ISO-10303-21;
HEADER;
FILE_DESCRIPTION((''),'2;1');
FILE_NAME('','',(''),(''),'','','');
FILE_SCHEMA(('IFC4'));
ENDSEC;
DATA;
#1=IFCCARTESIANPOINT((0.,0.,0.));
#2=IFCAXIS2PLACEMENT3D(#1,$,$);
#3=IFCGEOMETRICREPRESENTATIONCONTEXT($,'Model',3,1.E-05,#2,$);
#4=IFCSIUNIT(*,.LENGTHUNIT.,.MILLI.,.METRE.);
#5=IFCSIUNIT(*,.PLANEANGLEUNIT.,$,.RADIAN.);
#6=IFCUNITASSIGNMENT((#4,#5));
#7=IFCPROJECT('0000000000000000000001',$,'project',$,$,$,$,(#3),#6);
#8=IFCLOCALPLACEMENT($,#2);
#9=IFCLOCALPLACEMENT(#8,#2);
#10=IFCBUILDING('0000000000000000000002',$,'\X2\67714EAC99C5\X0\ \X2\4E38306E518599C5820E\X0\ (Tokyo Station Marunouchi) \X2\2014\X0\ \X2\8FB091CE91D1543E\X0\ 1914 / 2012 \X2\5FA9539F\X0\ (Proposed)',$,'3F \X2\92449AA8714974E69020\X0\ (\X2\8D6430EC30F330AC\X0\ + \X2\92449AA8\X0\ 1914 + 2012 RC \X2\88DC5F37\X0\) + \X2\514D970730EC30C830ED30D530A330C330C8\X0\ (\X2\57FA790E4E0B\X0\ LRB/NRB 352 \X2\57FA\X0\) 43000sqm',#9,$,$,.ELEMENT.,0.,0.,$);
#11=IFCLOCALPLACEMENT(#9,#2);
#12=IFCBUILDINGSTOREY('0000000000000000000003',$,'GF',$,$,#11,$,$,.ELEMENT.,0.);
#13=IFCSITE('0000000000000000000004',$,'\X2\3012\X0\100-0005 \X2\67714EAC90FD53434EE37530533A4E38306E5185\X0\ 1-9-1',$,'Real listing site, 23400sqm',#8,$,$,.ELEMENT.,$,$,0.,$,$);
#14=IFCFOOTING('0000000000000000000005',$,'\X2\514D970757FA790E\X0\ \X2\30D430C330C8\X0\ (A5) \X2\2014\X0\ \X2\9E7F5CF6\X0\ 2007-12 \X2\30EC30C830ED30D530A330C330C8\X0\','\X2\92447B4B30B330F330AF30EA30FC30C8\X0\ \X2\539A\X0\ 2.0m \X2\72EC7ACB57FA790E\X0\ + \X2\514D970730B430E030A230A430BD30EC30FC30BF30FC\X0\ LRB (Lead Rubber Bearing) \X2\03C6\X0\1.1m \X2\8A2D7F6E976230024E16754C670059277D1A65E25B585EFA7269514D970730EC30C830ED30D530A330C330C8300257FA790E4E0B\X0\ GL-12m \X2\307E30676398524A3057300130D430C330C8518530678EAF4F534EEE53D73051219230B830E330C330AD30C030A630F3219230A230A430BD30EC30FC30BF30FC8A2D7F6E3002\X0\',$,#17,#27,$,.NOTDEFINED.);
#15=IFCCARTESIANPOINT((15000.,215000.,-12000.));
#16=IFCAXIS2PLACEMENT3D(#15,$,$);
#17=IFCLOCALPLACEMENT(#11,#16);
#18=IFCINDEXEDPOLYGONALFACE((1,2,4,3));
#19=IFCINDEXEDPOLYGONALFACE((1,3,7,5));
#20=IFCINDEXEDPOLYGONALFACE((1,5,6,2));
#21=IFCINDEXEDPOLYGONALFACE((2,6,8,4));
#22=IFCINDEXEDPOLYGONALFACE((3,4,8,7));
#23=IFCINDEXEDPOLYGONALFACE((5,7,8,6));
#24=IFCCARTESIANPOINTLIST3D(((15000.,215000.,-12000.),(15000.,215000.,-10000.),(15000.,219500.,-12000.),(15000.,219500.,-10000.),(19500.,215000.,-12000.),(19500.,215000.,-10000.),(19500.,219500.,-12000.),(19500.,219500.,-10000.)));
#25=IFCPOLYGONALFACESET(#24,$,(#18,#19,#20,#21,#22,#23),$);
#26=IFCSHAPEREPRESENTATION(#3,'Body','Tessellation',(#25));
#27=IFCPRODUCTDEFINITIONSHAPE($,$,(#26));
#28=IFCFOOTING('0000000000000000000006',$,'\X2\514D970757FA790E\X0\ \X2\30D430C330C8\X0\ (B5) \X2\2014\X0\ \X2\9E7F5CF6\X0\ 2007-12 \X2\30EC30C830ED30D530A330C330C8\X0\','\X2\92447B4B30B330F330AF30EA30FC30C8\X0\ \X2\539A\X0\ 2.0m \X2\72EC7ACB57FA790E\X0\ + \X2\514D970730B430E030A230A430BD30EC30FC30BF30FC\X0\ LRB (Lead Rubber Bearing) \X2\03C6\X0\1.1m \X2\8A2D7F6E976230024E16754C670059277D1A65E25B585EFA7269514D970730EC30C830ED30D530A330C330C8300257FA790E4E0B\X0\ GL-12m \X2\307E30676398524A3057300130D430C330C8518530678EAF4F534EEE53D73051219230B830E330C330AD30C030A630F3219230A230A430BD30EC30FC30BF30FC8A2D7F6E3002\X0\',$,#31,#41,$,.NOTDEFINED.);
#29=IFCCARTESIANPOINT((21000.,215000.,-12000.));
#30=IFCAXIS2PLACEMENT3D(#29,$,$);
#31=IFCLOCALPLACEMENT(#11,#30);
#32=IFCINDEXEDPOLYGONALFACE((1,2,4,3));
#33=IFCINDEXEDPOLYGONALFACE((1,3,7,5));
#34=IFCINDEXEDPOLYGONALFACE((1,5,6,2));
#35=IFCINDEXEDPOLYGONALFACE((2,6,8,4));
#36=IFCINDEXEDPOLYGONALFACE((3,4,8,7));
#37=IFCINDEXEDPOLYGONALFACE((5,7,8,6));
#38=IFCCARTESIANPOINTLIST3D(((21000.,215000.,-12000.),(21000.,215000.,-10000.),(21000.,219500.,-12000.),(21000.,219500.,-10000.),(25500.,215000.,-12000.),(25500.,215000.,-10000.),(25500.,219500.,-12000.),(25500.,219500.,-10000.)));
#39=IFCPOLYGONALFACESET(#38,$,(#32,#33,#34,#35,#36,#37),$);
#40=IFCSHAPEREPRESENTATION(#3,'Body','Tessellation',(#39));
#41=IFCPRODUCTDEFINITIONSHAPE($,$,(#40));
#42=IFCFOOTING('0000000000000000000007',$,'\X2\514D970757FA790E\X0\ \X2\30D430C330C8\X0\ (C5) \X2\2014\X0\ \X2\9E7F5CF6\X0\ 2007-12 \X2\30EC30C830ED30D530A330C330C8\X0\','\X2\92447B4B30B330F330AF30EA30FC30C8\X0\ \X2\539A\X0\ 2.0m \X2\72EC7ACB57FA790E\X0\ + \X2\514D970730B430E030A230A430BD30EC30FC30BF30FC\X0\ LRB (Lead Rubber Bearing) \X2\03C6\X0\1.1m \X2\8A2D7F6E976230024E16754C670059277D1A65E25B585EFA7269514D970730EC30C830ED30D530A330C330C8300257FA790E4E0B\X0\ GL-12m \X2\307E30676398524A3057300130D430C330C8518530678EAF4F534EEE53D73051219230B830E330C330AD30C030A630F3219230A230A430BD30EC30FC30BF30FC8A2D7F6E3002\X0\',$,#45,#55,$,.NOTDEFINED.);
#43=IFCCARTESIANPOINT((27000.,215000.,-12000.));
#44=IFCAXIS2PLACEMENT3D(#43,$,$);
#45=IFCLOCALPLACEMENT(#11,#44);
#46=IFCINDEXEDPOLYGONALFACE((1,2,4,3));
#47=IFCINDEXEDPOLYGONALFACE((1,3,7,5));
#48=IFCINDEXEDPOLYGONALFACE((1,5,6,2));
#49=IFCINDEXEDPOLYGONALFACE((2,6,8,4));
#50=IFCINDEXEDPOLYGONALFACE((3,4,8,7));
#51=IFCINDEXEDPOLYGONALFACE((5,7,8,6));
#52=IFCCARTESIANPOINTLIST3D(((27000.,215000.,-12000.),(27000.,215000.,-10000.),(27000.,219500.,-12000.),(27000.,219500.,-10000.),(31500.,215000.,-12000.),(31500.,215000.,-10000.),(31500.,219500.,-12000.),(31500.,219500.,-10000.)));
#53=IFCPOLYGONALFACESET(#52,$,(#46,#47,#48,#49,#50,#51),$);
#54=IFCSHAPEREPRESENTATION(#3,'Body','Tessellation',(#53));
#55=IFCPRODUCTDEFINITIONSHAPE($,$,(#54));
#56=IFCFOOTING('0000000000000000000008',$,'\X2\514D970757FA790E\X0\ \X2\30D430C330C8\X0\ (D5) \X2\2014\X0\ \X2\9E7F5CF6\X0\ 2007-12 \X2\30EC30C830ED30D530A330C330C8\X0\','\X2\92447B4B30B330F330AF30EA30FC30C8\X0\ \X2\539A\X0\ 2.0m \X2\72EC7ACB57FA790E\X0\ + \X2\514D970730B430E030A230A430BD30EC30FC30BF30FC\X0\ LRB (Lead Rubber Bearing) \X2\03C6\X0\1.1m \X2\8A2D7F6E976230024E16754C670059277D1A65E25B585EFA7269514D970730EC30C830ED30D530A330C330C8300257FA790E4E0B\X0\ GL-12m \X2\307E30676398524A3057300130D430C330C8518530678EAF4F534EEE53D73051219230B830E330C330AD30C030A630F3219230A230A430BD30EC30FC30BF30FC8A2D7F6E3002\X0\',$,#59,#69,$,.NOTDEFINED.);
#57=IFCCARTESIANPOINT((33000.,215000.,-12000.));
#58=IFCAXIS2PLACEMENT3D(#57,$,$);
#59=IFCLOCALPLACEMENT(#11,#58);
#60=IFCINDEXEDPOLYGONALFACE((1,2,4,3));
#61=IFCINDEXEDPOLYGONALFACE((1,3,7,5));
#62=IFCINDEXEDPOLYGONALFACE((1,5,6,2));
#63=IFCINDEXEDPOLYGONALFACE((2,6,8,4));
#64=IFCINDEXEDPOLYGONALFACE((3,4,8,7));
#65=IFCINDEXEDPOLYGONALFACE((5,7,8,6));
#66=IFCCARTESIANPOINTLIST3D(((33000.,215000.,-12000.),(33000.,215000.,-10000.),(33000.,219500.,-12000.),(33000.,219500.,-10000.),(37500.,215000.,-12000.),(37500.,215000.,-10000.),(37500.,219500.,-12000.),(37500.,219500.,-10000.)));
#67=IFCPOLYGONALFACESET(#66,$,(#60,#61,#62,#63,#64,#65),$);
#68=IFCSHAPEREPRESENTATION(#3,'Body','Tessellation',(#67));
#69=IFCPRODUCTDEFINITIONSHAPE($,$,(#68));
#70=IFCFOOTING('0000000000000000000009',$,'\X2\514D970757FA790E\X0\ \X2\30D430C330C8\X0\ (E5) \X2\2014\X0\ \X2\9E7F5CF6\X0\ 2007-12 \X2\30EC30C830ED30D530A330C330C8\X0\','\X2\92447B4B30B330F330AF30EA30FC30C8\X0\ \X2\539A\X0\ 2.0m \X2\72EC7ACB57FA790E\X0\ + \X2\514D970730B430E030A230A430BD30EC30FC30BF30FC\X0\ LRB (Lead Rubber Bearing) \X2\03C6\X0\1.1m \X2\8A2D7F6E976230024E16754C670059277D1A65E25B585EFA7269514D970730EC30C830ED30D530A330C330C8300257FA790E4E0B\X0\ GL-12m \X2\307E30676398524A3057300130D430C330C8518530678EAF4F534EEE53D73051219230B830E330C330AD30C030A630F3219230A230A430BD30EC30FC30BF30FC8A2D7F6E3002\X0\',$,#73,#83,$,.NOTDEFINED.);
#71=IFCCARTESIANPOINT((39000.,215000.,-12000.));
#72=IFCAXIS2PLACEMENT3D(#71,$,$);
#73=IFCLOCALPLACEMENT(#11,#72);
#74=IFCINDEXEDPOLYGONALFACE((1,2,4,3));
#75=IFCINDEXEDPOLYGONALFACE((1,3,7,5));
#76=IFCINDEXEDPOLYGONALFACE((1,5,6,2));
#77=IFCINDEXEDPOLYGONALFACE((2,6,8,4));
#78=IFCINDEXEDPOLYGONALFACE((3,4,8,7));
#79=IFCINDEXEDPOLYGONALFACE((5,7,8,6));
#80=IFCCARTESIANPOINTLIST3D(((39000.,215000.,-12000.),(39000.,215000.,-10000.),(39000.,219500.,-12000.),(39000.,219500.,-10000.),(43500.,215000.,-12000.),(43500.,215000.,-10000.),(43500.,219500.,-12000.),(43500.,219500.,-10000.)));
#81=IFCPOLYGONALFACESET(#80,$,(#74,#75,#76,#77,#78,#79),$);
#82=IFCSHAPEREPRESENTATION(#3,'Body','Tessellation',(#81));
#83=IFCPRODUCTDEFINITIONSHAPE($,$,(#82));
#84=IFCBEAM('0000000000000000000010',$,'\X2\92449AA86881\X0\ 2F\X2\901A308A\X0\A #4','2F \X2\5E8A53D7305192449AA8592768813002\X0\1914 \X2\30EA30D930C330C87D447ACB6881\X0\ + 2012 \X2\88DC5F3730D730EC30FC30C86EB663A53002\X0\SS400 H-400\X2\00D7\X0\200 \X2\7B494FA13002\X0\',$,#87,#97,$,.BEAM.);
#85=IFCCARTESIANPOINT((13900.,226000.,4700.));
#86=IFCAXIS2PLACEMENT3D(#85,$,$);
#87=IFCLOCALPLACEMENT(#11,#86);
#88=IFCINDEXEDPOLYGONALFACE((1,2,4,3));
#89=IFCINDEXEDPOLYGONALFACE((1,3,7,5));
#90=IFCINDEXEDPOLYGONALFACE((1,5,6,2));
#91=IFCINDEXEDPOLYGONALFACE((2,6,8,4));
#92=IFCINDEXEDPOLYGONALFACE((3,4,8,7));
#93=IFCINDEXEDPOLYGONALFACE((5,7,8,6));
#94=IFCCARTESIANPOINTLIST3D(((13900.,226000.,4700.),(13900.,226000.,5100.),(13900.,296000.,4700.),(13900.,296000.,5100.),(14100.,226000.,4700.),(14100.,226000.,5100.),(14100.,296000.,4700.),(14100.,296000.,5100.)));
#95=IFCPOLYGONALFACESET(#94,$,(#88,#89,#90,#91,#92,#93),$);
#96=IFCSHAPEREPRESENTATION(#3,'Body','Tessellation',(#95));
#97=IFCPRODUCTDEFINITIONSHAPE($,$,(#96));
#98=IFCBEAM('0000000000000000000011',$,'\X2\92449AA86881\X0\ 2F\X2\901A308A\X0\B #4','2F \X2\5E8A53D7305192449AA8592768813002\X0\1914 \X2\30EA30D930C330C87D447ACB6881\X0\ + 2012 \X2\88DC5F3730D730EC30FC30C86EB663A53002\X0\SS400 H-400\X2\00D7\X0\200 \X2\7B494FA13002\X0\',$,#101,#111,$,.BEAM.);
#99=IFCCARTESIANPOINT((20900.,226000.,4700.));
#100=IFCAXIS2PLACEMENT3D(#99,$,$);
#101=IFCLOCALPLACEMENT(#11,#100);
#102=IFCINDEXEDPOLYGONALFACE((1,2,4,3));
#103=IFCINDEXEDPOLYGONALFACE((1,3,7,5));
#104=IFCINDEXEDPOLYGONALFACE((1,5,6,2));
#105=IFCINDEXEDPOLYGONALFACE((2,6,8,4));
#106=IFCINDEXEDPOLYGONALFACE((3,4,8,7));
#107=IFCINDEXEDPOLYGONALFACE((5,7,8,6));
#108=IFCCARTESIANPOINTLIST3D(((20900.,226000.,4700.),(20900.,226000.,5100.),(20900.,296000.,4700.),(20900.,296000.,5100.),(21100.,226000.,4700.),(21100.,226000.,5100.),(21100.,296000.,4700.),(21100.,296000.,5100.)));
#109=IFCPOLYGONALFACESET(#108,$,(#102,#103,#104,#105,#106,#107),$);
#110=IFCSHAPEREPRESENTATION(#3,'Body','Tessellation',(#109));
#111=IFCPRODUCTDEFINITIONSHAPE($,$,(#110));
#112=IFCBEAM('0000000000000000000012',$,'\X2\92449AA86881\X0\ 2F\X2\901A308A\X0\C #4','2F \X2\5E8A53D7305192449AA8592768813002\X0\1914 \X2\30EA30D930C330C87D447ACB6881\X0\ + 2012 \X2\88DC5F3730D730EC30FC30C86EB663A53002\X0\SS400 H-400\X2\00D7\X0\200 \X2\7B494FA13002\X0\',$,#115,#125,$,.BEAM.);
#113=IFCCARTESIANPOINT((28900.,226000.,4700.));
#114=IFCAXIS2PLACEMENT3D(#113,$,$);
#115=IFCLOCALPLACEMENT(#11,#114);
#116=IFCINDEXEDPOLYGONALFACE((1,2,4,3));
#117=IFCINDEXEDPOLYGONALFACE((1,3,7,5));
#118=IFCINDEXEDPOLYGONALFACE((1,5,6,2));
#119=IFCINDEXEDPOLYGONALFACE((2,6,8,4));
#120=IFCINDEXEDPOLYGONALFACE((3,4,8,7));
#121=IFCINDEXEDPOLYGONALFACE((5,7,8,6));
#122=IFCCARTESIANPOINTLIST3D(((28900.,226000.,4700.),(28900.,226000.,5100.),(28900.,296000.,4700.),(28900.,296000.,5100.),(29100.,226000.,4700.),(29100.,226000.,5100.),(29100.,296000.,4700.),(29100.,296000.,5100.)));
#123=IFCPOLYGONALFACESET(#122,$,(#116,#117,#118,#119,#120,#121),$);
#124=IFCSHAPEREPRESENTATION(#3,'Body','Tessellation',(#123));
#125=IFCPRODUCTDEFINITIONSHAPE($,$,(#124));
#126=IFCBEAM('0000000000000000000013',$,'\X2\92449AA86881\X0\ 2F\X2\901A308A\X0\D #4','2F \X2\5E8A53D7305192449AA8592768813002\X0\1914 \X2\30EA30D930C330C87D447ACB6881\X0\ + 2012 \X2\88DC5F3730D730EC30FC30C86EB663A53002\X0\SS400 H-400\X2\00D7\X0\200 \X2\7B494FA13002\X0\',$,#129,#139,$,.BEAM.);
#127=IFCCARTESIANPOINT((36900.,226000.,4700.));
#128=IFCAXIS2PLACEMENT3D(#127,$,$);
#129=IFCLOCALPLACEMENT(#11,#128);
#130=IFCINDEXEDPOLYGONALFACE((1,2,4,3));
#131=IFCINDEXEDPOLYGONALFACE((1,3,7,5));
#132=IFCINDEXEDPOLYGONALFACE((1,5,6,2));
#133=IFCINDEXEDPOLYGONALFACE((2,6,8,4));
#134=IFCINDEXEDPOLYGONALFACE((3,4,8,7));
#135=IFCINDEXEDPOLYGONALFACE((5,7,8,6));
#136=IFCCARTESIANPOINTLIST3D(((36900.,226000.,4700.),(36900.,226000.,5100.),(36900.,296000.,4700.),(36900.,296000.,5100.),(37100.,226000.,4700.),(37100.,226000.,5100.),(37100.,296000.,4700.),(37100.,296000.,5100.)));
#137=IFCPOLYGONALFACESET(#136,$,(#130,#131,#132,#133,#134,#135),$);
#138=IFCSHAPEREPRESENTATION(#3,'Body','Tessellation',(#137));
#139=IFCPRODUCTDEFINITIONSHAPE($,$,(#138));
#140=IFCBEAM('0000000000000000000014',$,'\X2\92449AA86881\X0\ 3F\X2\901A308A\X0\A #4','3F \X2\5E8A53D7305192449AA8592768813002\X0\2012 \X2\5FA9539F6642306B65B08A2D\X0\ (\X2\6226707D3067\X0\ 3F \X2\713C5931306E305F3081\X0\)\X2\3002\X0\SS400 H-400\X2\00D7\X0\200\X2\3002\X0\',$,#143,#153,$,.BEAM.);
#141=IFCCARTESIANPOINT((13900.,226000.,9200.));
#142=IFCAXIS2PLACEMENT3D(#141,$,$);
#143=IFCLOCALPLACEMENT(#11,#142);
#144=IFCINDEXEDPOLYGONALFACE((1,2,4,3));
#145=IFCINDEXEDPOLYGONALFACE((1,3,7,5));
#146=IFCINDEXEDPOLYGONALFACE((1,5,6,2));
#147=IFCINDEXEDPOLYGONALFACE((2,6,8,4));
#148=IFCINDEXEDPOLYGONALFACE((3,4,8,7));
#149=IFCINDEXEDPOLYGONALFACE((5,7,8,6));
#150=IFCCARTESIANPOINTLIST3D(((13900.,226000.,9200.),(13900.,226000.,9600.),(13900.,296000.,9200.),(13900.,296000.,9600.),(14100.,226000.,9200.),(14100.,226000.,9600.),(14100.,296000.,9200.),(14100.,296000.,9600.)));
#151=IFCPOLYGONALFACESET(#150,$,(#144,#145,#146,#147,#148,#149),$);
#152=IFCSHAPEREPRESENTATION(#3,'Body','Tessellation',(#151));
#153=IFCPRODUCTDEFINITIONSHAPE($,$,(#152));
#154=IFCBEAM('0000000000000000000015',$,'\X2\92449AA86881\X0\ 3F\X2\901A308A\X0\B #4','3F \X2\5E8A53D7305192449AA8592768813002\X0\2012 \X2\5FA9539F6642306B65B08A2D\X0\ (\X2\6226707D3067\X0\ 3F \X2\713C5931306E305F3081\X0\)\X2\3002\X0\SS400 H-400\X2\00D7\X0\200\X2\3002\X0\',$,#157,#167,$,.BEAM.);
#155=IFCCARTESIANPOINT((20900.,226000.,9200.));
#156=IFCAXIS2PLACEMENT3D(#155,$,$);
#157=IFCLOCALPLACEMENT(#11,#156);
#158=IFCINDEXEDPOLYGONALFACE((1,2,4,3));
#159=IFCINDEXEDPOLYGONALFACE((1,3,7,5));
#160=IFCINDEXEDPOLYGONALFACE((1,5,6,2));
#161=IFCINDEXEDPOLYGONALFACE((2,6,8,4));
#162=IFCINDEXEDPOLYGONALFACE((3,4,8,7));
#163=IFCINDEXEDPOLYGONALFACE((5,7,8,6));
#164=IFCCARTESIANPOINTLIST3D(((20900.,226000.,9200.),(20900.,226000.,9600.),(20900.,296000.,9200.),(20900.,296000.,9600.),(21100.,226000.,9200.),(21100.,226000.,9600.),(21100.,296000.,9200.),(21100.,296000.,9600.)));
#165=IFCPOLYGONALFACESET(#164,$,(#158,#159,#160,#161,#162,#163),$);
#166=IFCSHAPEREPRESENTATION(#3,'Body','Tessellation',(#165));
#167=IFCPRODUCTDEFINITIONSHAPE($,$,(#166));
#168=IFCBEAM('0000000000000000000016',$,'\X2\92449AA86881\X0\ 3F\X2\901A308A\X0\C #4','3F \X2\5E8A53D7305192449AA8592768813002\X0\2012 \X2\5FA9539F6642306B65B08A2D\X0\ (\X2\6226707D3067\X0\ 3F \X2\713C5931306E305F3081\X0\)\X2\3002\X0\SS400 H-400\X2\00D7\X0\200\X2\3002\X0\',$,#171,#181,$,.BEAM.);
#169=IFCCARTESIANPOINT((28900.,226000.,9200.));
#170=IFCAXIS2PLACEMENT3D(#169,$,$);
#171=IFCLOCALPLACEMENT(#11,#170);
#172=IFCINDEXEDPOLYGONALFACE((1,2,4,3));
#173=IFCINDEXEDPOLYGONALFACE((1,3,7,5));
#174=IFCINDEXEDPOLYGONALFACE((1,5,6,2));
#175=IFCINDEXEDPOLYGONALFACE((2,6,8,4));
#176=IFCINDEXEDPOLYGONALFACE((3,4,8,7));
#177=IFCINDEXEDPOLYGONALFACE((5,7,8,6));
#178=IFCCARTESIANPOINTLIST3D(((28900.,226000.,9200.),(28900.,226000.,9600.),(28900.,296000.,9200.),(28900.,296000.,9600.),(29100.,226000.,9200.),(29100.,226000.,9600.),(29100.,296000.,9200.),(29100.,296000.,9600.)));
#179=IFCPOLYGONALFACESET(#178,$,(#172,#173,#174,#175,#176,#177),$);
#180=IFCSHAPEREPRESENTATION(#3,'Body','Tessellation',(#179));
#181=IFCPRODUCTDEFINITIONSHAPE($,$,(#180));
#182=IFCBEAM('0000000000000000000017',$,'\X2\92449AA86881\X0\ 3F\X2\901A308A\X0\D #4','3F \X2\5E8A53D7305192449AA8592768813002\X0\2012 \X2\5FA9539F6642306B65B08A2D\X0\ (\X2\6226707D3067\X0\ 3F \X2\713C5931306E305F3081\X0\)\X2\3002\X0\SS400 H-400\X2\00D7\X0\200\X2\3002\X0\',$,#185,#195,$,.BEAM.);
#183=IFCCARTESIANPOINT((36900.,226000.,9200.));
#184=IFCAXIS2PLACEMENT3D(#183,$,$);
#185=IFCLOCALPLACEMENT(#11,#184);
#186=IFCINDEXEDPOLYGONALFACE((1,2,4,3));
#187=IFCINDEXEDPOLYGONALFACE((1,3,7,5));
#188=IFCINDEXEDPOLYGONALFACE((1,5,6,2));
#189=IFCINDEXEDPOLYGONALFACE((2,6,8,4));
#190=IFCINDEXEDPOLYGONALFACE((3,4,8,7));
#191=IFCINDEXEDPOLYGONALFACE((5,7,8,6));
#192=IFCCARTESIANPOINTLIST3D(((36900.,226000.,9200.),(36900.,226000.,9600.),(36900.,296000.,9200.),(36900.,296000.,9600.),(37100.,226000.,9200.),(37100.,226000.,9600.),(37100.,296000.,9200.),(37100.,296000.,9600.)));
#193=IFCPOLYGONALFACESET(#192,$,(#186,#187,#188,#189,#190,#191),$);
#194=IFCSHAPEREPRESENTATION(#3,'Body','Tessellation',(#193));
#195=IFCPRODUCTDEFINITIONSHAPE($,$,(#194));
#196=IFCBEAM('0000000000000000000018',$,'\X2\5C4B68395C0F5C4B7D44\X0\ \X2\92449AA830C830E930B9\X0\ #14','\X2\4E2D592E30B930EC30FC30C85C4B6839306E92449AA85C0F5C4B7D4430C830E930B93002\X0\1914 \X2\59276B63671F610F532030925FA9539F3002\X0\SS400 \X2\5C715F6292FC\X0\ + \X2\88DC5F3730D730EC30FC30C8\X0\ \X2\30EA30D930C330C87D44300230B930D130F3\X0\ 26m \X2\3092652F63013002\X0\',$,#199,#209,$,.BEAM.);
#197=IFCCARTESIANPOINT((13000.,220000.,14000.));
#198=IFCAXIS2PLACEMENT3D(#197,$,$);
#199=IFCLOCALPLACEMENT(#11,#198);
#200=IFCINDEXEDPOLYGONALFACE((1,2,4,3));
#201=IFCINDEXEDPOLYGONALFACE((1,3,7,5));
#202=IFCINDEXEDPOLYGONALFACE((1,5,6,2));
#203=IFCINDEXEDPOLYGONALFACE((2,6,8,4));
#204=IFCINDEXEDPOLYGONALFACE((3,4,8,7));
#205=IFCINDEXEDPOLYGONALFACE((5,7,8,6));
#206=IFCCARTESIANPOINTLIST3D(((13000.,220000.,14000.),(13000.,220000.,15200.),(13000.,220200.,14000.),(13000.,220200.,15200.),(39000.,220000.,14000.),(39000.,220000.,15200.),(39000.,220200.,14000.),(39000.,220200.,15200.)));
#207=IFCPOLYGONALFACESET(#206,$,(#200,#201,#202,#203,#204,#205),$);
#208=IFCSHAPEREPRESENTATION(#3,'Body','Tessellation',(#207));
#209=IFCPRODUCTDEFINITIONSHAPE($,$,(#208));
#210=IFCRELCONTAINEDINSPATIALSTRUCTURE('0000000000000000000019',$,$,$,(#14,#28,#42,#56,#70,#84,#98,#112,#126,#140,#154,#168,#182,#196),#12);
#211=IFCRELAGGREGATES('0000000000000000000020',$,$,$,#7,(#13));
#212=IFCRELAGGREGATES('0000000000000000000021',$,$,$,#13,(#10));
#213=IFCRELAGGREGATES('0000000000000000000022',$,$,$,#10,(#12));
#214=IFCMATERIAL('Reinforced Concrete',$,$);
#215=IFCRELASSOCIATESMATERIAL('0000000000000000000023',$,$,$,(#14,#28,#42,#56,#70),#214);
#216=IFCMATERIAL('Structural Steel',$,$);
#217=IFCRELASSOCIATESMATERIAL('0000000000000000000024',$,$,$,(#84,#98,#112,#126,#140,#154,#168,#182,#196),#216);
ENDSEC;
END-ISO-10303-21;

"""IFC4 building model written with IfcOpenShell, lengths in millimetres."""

from ifc_helpers import new_model, si_unit, frame, frame_2d, origin, place, context, project, spatial, rectangle, extrude, material, element, save


model = new_model("IFC4")

# Units and contexts
model_context = context("Model", 3, precision=1e-05, world=origin())
ifc_project = project(units=[si_unit("LENGTHUNIT", "METRE", prefix="MILLI"), si_unit("PLANEANGLEUNIT", "RADIAN")], contexts=[model_context])

# Site, building, storey
site_placement = place(None, origin())
site = spatial("IfcSite", under=ifc_project, at=site_placement, Name="〒100-0005 東京都千代田区丸の内 1-9-1", ObjectType="Real listing site, 23400sqm", CompositionType="ELEMENT", RefElevation=0.0)
building_placement = place(site_placement, origin())
building = spatial("IfcBuilding", under=site, at=building_placement, Name="東京駅 丸の内駅舎 (Tokyo Station Marunouchi) — 辰野金吾 1914 / 2012 復原 (Proposed)", ObjectType="3F 鉄骨煉瓦造 (赤レンガ + 鉄骨 1914 + 2012 RC 補強) + 免震レトロフィット (基礎下 LRB/NRB 352 基) 43000sqm", CompositionType="ELEMENT", ElevationOfRefHeight=0.0, ElevationOfTerrain=0.0)
storey_placement = place(building_placement, origin())
storey = spatial("IfcBuildingStorey", under=building, at=storey_placement, Name="GF", CompositionType="ELEMENT", Elevation=0.0)

# Footings
ifc_material_1 = material(Name="Reinforced Concrete")
footing_1_placement = place(storey_placement, frame((15000.0, 215000.0, -12000.0)))
element("IfcFooting", 1, at=footing_1_placement, inside=storey, material=ifc_material_1, Name="免震基礎 ピット (A5) — 鹿島 2007-12 レトロフィット", Description="鉄筋コンクリート 厚 2.0m 独立基礎 + 免震ゴムアイソレーター LRB (Lead Rubber Bearing) φ1.1m 設置面。世界最大級既存建物免震レトロフィット。基礎下 GL-12m まで掘削し、ピット内で躯体仮受け→ジャッキダウン→アイソレーター設置。", PredefinedType="NOTDEFINED", context=model_context, shape_type="SweptSolid", body=[
    extrude(rectangle(XDim=4500.0, YDim=4500.0, at=frame_2d((2250.0, 2250.0))), frame((15000.0, 215000.0, -12000.0)), (0.0, 0.0, 1.0), 2000.0),
])
footing_2_placement = place(storey_placement, frame((21000.0, 215000.0, -12000.0)))
element("IfcFooting", 2, at=footing_2_placement, inside=storey, material=ifc_material_1, Name="免震基礎 ピット (B5) — 鹿島 2007-12 レトロフィット", Description="鉄筋コンクリート 厚 2.0m 独立基礎 + 免震ゴムアイソレーター LRB (Lead Rubber Bearing) φ1.1m 設置面。世界最大級既存建物免震レトロフィット。基礎下 GL-12m まで掘削し、ピット内で躯体仮受け→ジャッキダウン→アイソレーター設置。", PredefinedType="NOTDEFINED", context=model_context, shape_type="SweptSolid", body=[
    extrude(rectangle(XDim=4500.0, YDim=4500.0, at=frame_2d((2250.0, 2250.0))), frame((21000.0, 215000.0, -12000.0)), (0.0, 0.0, 1.0), 2000.0),
])
footing_3_placement = place(storey_placement, frame((27000.0, 215000.0, -12000.0)))
element("IfcFooting", 3, at=footing_3_placement, inside=storey, material=ifc_material_1, Name="免震基礎 ピット (C5) — 鹿島 2007-12 レトロフィット", Description="鉄筋コンクリート 厚 2.0m 独立基礎 + 免震ゴムアイソレーター LRB (Lead Rubber Bearing) φ1.1m 設置面。世界最大級既存建物免震レトロフィット。基礎下 GL-12m まで掘削し、ピット内で躯体仮受け→ジャッキダウン→アイソレーター設置。", PredefinedType="NOTDEFINED", context=model_context, shape_type="SweptSolid", body=[
    extrude(rectangle(XDim=4500.0, YDim=4500.0, at=frame_2d((2250.0, 2250.0))), frame((27000.0, 215000.0, -12000.0)), (0.0, 0.0, 1.0), 2000.0),
])
footing_4_placement = place(storey_placement, frame((33000.0, 215000.0, -12000.0)))
element("IfcFooting", 4, at=footing_4_placement, inside=storey, material=ifc_material_1, Name="免震基礎 ピット (D5) — 鹿島 2007-12 レトロフィット", Description="鉄筋コンクリート 厚 2.0m 独立基礎 + 免震ゴムアイソレーター LRB (Lead Rubber Bearing) φ1.1m 設置面。世界最大級既存建物免震レトロフィット。基礎下 GL-12m まで掘削し、ピット内で躯体仮受け→ジャッキダウン→アイソレーター設置。", PredefinedType="NOTDEFINED", context=model_context, shape_type="SweptSolid", body=[
    extrude(rectangle(XDim=4500.0, YDim=4500.0, at=frame_2d((2250.0, 2250.0))), frame((33000.0, 215000.0, -12000.0)), (0.0, 0.0, 1.0), 2000.0),
])
footing_5_placement = place(storey_placement, frame((39000.0, 215000.0, -12000.0)))
element("IfcFooting", 5, at=footing_5_placement, inside=storey, material=ifc_material_1, Name="免震基礎 ピット (E5) — 鹿島 2007-12 レトロフィット", Description="鉄筋コンクリート 厚 2.0m 独立基礎 + 免震ゴムアイソレーター LRB (Lead Rubber Bearing) φ1.1m 設置面。世界最大級既存建物免震レトロフィット。基礎下 GL-12m まで掘削し、ピット内で躯体仮受け→ジャッキダウン→アイソレーター設置。", PredefinedType="NOTDEFINED", context=model_context, shape_type="SweptSolid", body=[
    extrude(rectangle(XDim=4500.0, YDim=4500.0, at=frame_2d((2250.0, 2250.0))), frame((39000.0, 215000.0, -12000.0)), (0.0, 0.0, 1.0), 2000.0),
])

# Beams
ifc_material_2 = material(Name="Structural Steel")
beam_1_placement = place(storey_placement, frame((13900.0, 226000.0, 4700.0)))
element("IfcBeam", 6, at=beam_1_placement, inside=storey, material=ifc_material_2, Name="鉄骨梁 2F通りA #4", Description="2F 床受け鉄骨大梁。1914 リベット組立梁 + 2012 補強プレート溶接。SS400 H-400×200 等価。", PredefinedType="BEAM", context=model_context, shape_type="SweptSolid", body=[
    extrude(rectangle(XDim=200.0, YDim=70000.0, at=frame_2d((100.0, 35000.0))), frame((13900.0, 226000.0, 4700.0)), (0.0, 0.0, 1.0), 400.0),
])
beam_2_placement = place(storey_placement, frame((20900.0, 226000.0, 4700.0)))
element("IfcBeam", 7, at=beam_2_placement, inside=storey, material=ifc_material_2, Name="鉄骨梁 2F通りB #4", Description="2F 床受け鉄骨大梁。1914 リベット組立梁 + 2012 補強プレート溶接。SS400 H-400×200 等価。", PredefinedType="BEAM", context=model_context, shape_type="SweptSolid", body=[
    extrude(rectangle(XDim=200.0, YDim=70000.0, at=frame_2d((100.0, 35000.0))), frame((20900.0, 226000.0, 4700.0)), (0.0, 0.0, 1.0), 400.0),
])
beam_3_placement = place(storey_placement, frame((28900.0, 226000.0, 4700.0)))
element("IfcBeam", 8, at=beam_3_placement, inside=storey, material=ifc_material_2, Name="鉄骨梁 2F通りC #4", Description="2F 床受け鉄骨大梁。1914 リベット組立梁 + 2012 補強プレート溶接。SS400 H-400×200 等価。", PredefinedType="BEAM", context=model_context, shape_type="SweptSolid", body=[
    extrude(rectangle(XDim=200.0, YDim=70000.0, at=frame_2d((100.0, 35000.0))), frame((28900.0, 226000.0, 4700.0)), (0.0, 0.0, 1.0), 400.0),
])
beam_4_placement = place(storey_placement, frame((36900.0, 226000.0, 4700.0)))
element("IfcBeam", 9, at=beam_4_placement, inside=storey, material=ifc_material_2, Name="鉄骨梁 2F通りD #4", Description="2F 床受け鉄骨大梁。1914 リベット組立梁 + 2012 補強プレート溶接。SS400 H-400×200 等価。", PredefinedType="BEAM", context=model_context, shape_type="SweptSolid", body=[
    extrude(rectangle(XDim=200.0, YDim=70000.0, at=frame_2d((100.0, 35000.0))), frame((36900.0, 226000.0, 4700.0)), (0.0, 0.0, 1.0), 400.0),
])
beam_5_placement = place(storey_placement, frame((13900.0, 226000.0, 9200.0)))
element("IfcBeam", 10, at=beam_5_placement, inside=storey, material=ifc_material_2, Name="鉄骨梁 3F通りA #4", Description="3F 床受け鉄骨大梁。2012 復原時に新設 (戦災で 3F 焼失のため)。SS400 H-400×200。", PredefinedType="BEAM", context=model_context, shape_type="SweptSolid", body=[
    extrude(rectangle(XDim=200.0, YDim=70000.0, at=frame_2d((100.0, 35000.0))), frame((13900.0, 226000.0, 9200.0)), (0.0, 0.0, 1.0), 400.0),
])
beam_6_placement = place(storey_placement, frame((20900.0, 226000.0, 9200.0)))
element("IfcBeam", 11, at=beam_6_placement, inside=storey, material=ifc_material_2, Name="鉄骨梁 3F通りB #4", Description="3F 床受け鉄骨大梁。2012 復原時に新設 (戦災で 3F 焼失のため)。SS400 H-400×200。", PredefinedType="BEAM", context=model_context, shape_type="SweptSolid", body=[
    extrude(rectangle(XDim=200.0, YDim=70000.0, at=frame_2d((100.0, 35000.0))), frame((20900.0, 226000.0, 9200.0)), (0.0, 0.0, 1.0), 400.0),
])
beam_7_placement = place(storey_placement, frame((28900.0, 226000.0, 9200.0)))
element("IfcBeam", 12, at=beam_7_placement, inside=storey, material=ifc_material_2, Name="鉄骨梁 3F通りC #4", Description="3F 床受け鉄骨大梁。2012 復原時に新設 (戦災で 3F 焼失のため)。SS400 H-400×200。", PredefinedType="BEAM", context=model_context, shape_type="SweptSolid", body=[
    extrude(rectangle(XDim=200.0, YDim=70000.0, at=frame_2d((100.0, 35000.0))), frame((28900.0, 226000.0, 9200.0)), (0.0, 0.0, 1.0), 400.0),
])
beam_8_placement = place(storey_placement, frame((36900.0, 226000.0, 9200.0)))
element("IfcBeam", 13, at=beam_8_placement, inside=storey, material=ifc_material_2, Name="鉄骨梁 3F通りD #4", Description="3F 床受け鉄骨大梁。2012 復原時に新設 (戦災で 3F 焼失のため)。SS400 H-400×200。", PredefinedType="BEAM", context=model_context, shape_type="SweptSolid", body=[
    extrude(rectangle(XDim=200.0, YDim=70000.0, at=frame_2d((100.0, 35000.0))), frame((36900.0, 226000.0, 9200.0)), (0.0, 0.0, 1.0), 400.0),
])
beam_9_placement = place(storey_placement, frame((13000.0, 220000.0, 14000.0)))
element("IfcBeam", 14, at=beam_9_placement, inside=storey, material=ifc_material_2, Name="屋根小屋組 鉄骨トラス #14", Description="中央スレート屋根の鉄骨小屋組トラス。1914 大正期意匠を復原。SS400 山形鋼 + 補強プレート リベット組。スパン 26m を支持。", PredefinedType="BEAM", context=model_context, shape_type="SweptSolid", body=[
    extrude(rectangle(XDim=26000.0, YDim=200.0, at=frame_2d((13000.0, 100.0))), frame((13000.0, 220000.0, 14000.0)), (0.0, 0.0, 1.0), 1200.0),
])

save(model, "model.ifc")
